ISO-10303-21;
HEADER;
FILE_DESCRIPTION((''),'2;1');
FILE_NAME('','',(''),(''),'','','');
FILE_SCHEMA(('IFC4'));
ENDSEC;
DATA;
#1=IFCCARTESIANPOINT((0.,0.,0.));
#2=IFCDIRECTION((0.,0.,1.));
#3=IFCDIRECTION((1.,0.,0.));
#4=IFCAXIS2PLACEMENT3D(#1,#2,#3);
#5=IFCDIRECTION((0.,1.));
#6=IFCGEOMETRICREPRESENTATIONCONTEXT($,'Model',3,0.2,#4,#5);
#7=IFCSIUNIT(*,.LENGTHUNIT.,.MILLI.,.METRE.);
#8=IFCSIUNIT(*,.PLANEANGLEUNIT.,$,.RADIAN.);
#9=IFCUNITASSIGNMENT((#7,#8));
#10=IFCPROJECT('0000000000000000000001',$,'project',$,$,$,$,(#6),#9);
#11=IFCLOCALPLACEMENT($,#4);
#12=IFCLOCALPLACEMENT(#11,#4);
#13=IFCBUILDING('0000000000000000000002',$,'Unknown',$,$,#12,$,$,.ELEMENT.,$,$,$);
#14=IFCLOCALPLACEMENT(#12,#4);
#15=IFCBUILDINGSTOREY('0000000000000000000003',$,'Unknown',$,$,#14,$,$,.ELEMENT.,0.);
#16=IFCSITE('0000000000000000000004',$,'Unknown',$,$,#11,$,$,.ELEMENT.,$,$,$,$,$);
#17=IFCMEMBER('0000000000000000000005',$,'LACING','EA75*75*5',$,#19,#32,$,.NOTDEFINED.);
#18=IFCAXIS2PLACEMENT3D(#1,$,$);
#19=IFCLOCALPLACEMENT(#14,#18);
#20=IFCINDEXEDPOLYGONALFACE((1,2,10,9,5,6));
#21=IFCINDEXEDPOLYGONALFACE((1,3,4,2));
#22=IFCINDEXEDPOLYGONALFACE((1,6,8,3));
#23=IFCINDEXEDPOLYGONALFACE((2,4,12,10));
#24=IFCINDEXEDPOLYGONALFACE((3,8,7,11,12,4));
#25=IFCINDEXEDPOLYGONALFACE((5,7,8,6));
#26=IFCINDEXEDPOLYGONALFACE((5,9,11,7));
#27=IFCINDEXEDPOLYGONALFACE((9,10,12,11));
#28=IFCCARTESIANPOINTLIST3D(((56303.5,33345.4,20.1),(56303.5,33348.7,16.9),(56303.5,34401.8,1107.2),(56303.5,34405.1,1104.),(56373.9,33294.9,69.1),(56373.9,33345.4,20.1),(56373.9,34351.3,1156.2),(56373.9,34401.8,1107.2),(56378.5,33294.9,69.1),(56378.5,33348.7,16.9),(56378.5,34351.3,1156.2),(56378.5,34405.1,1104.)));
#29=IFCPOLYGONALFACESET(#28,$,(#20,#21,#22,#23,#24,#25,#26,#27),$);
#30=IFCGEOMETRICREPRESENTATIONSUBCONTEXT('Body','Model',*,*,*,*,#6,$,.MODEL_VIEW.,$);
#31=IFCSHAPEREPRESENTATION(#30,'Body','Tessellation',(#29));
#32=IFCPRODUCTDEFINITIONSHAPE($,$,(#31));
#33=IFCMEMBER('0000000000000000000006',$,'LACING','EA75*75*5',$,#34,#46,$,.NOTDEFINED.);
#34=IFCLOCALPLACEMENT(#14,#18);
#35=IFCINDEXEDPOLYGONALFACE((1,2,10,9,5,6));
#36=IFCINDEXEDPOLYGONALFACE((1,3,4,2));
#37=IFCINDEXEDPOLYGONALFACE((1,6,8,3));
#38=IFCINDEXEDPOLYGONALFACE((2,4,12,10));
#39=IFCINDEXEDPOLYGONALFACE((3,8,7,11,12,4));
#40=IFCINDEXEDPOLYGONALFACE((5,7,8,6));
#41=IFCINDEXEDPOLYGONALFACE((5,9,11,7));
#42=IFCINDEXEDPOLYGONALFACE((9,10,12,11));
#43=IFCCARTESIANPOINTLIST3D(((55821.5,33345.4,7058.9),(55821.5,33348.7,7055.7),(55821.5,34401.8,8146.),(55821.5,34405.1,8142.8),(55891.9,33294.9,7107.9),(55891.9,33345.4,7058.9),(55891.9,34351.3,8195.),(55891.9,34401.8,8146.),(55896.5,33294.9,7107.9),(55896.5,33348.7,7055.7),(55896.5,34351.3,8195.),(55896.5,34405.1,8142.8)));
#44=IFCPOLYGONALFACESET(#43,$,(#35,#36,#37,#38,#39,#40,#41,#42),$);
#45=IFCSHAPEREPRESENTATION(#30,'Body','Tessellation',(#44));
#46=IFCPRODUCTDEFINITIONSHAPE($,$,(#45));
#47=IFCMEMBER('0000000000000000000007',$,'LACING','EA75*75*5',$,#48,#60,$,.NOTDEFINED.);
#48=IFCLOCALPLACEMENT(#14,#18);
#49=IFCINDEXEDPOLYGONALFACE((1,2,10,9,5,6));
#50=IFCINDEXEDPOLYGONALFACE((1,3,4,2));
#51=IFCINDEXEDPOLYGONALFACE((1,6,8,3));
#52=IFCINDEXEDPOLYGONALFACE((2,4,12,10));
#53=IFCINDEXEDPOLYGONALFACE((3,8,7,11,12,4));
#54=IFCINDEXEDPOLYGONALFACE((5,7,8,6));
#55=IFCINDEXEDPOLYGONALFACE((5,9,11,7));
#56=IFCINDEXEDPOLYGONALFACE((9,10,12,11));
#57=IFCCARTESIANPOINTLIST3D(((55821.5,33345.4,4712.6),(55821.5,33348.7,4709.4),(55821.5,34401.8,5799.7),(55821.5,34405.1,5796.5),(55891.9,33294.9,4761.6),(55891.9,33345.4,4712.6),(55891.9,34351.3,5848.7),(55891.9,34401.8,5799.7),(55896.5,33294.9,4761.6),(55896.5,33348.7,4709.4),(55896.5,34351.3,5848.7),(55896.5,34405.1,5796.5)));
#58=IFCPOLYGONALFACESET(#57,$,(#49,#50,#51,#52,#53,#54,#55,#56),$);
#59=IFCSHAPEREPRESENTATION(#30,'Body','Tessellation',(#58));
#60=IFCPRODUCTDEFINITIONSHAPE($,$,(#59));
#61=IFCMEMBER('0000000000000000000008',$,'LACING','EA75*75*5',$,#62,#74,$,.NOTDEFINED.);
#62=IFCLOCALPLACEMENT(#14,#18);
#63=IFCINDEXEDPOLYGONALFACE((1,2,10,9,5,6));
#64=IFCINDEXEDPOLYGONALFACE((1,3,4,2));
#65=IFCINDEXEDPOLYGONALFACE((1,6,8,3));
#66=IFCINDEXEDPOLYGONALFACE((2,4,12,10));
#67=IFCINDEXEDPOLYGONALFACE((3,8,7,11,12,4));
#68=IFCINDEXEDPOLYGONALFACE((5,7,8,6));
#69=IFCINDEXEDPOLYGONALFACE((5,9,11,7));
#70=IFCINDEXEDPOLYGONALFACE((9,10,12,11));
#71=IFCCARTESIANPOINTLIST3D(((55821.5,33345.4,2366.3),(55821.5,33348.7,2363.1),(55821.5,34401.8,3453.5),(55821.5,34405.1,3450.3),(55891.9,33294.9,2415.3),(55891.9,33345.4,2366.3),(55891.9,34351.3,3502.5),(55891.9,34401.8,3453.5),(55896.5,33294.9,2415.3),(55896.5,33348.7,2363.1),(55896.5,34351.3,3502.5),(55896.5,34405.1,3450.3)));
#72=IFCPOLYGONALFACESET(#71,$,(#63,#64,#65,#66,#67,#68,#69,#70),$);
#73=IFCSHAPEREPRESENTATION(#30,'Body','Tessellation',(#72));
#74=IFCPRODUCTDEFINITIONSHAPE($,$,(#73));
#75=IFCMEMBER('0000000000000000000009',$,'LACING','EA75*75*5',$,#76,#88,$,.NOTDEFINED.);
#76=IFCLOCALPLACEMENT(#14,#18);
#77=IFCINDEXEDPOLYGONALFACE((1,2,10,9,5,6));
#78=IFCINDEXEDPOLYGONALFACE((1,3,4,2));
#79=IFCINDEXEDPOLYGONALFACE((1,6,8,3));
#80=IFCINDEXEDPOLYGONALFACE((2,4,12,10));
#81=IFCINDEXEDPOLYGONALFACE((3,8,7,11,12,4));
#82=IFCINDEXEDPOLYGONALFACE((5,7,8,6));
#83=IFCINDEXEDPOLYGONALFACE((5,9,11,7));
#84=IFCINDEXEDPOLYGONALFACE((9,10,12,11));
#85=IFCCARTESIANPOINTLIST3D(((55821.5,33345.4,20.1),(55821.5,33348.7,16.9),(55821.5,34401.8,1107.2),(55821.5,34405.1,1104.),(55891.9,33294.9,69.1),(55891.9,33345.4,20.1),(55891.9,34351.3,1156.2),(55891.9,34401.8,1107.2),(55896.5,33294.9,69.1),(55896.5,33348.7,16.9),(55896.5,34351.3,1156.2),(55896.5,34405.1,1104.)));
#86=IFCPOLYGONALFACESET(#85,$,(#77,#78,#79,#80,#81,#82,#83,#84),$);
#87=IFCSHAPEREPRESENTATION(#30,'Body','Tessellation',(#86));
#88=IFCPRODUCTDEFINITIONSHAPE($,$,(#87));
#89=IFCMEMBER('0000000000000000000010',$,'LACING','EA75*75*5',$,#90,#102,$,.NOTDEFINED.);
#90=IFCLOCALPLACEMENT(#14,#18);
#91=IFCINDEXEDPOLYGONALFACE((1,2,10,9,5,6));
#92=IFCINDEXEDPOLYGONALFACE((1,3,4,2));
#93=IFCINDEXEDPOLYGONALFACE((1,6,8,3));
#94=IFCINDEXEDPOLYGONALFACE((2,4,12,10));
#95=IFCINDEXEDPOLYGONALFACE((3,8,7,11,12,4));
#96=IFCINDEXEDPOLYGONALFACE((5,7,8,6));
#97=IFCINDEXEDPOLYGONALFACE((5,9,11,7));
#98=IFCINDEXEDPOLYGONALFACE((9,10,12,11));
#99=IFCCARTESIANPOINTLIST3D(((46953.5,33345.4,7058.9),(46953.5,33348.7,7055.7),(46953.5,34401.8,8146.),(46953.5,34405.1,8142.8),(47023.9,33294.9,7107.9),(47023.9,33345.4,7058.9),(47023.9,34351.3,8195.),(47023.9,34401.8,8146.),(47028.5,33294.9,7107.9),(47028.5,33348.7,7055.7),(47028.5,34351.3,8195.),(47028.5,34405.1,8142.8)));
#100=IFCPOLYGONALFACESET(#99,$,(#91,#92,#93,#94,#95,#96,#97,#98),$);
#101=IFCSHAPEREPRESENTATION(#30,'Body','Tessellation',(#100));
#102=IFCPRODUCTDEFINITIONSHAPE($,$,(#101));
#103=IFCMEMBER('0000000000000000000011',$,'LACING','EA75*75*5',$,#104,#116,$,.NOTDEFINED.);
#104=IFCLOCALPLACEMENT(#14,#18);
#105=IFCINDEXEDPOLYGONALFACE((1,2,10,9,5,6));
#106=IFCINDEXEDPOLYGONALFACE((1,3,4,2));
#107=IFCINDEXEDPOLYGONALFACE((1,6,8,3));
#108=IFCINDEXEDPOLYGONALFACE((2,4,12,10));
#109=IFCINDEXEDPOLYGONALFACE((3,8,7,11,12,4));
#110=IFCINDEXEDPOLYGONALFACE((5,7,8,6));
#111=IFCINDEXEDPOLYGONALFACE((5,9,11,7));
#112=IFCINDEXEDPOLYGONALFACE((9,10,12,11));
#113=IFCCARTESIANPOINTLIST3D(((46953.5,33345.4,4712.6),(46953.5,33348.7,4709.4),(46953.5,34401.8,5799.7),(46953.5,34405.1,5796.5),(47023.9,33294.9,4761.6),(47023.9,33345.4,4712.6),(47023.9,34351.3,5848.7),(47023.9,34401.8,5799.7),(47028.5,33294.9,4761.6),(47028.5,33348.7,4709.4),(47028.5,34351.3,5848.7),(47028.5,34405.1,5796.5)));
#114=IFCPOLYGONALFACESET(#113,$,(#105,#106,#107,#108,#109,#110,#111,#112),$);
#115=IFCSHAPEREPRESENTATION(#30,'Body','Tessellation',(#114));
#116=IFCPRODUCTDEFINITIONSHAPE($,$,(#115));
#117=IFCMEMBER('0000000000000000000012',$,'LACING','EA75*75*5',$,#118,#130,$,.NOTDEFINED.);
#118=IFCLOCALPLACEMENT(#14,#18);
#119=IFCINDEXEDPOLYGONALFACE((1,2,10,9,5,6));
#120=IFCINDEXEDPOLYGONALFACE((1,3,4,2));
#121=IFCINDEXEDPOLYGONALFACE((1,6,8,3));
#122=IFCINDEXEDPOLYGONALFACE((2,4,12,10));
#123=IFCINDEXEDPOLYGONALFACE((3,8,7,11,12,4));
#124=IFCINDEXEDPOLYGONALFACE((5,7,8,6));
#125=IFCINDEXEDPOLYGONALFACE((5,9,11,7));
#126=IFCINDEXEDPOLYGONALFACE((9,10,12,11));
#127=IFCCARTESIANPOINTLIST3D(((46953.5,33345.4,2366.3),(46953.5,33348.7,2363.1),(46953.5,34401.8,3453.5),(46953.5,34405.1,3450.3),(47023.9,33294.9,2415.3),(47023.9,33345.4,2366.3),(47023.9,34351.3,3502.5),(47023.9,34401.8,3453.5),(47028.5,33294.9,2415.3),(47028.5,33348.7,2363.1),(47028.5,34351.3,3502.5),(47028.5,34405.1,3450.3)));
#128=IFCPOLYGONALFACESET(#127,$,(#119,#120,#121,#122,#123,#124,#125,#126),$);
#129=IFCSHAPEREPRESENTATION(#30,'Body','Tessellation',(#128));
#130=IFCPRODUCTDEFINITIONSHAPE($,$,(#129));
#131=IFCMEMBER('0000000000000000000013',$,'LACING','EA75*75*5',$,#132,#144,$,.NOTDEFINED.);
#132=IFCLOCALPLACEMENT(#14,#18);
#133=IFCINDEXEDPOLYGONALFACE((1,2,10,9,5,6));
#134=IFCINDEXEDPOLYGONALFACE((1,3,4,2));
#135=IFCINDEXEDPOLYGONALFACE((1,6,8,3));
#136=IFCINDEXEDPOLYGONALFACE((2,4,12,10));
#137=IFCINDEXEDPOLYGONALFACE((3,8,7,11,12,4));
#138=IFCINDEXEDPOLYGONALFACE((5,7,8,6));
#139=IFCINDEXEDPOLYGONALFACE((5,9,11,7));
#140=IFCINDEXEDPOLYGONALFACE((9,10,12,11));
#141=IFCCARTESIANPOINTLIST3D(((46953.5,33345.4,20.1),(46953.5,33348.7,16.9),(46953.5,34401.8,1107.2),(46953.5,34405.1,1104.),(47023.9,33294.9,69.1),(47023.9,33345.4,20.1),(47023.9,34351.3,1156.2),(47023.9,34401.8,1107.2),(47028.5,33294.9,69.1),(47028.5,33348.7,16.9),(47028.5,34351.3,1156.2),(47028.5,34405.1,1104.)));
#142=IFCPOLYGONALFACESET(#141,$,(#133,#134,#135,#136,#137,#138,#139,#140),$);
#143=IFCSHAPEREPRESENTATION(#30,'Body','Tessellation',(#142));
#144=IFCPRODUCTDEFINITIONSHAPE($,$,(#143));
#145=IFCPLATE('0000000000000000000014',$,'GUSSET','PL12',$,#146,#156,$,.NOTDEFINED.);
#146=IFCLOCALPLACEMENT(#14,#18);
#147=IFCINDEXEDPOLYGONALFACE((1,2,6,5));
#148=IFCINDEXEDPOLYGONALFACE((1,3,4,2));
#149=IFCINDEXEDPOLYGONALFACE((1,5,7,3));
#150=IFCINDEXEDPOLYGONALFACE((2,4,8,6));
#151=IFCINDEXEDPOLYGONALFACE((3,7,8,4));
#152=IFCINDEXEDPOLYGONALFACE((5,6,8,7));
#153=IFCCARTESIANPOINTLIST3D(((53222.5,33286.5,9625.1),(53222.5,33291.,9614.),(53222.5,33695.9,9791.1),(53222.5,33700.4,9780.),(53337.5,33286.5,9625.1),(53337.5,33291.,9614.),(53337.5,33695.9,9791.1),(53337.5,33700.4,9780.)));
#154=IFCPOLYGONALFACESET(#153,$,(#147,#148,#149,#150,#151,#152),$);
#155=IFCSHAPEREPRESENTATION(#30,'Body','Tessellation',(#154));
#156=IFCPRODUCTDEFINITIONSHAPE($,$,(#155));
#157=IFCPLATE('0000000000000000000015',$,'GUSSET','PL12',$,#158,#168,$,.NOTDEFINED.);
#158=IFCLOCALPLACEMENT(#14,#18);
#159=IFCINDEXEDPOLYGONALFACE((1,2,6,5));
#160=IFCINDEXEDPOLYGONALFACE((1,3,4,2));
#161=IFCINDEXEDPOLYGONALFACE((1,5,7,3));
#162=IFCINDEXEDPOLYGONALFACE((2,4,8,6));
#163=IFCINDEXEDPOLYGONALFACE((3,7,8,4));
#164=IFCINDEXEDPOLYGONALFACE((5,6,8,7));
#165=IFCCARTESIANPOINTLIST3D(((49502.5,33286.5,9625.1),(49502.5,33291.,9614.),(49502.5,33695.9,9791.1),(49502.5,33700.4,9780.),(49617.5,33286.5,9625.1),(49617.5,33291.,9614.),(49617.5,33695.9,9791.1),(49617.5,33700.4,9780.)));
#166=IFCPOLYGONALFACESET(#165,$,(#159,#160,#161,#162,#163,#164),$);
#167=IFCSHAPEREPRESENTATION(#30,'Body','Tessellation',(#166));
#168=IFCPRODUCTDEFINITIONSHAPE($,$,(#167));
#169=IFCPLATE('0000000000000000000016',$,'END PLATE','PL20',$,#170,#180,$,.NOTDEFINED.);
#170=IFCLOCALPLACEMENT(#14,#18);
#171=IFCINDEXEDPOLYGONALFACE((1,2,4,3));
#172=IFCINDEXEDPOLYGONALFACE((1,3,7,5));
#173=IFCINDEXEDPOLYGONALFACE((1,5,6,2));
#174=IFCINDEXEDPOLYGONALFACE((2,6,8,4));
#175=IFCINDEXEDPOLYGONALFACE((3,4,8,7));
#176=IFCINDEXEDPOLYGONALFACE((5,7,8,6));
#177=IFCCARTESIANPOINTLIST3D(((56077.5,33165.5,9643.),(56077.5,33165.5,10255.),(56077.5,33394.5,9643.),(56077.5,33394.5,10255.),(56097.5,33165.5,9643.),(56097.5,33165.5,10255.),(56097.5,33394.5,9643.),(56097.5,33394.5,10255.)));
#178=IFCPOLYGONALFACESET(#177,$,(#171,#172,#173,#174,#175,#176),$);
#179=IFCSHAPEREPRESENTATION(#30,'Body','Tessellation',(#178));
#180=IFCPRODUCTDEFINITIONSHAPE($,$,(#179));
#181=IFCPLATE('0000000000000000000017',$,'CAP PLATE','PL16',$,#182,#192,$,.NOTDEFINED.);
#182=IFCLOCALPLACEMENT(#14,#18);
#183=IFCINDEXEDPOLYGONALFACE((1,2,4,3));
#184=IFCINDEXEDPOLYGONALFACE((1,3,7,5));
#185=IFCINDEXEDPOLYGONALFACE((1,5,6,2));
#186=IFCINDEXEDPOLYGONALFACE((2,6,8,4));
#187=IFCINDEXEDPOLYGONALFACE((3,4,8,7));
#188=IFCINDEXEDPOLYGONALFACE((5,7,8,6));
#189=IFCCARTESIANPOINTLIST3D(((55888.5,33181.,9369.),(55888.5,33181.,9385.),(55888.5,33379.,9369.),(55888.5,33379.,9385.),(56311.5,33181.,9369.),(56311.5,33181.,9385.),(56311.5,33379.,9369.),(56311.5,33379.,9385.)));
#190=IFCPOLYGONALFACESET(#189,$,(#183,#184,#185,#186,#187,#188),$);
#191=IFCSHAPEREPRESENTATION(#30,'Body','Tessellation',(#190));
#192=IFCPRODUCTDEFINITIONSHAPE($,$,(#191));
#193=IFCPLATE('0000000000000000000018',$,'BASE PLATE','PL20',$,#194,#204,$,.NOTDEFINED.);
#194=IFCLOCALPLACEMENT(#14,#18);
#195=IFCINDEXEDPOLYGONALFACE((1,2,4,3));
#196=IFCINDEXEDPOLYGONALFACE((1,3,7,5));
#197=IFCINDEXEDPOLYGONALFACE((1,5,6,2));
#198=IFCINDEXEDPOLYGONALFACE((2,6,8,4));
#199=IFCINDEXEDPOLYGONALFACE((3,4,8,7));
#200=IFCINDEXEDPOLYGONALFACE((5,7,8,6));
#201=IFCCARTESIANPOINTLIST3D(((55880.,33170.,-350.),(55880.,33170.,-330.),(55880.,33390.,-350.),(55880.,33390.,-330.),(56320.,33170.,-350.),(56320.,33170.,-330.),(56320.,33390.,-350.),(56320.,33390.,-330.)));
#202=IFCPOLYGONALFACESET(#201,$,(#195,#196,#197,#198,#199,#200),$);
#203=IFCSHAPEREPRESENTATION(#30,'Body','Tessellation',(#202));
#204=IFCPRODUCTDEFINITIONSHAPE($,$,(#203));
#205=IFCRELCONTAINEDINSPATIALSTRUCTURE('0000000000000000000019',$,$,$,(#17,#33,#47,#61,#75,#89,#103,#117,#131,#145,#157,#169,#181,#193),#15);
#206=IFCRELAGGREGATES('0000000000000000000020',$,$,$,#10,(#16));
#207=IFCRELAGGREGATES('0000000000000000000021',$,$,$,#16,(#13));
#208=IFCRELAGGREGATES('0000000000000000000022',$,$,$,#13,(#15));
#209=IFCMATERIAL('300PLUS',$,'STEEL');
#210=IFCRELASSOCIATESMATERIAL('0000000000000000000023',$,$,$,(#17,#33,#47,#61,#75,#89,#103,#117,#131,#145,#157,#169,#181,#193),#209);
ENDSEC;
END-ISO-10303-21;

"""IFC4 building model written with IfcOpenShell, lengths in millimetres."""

from ifc_helpers import new_model, si_unit, direction, frame, origin_with_axes, place, context, subcontext, project, spatial, line, indexed_curve, outline, extrude, material, element, save


model = new_model("IFC4")

# Units and contexts
model_context = context("Model", 3, precision=0.2, world=origin_with_axes(), true_north=direction((0.0, 1.0)))
body_context = subcontext(model_context, "Body", "Model", "MODEL_VIEW")
ifc_project = project(units=[si_unit("LENGTHUNIT", "METRE", prefix="MILLI"), si_unit("PLANEANGLEUNIT", "RADIAN")], contexts=[model_context])

# Site, building, storey
site_placement = place(None, origin_with_axes())
site = spatial("IfcSite", under=ifc_project, at=site_placement, Name="Unknown", CompositionType="ELEMENT")
building_placement = place(site_placement, origin_with_axes())
building = spatial("IfcBuilding", under=site, at=building_placement, Name="Unknown", CompositionType="ELEMENT")
storey_placement = place(building_placement, origin_with_axes())
storey = spatial("IfcBuildingStorey", under=building, at=storey_placement, Name="Unknown", CompositionType="ELEMENT", Elevation=0.0)

# Shared definitions
ifc_material_1 = material(Name="300PLUS", Category="STEEL")

# Members
for number, where, z_axis, x_axis, name in (
    (1, (56341.0, 33321.8, 43.0), (0.0, -0.717161, 0.696908), (0.0, 0.696908, 0.717161), "LACING"),
    (2, (55859.0, 33321.8, 7081.8), (0.0, -0.717161, 0.696908), (0.0, 0.696908, 0.717161), "LACING"),
    (3, (55859.0, 33321.8, 4735.5), (0.0, -0.717161, 0.696908), (0.0, 0.696908, 0.717161), "LACING"),
):
    element("IfcMember", number, at=place(storey_placement, frame(where, z_axis=z_axis, x_axis=x_axis)), inside=storey, material=ifc_material_1, Name=name, Description="EA75*75*5", PredefinedType="NOTDEFINED", context=body_context, shape_type="SolidModel", body=[
        extrude(outline(indexed_curve([(-37.5, -37.5), (37.5, -37.5), (37.5, -32.9), (-32.9, -32.9), (-32.9, 37.5), (-37.5, 37.5)], segments=[line(1, 2, 3, 4, 5, 6, 1)])), frame((0.0, 0.0, 0.0), z_axis=(-1.0, 0.0, 0.0), x_axis=(0.0, 0.0, 1.0)), (0.0, 0.0, -1.0), 1515.8),
    ])
member_1_placement = place(storey_placement, frame((55859.0, 33321.8, 2389.2), z_axis=(0.0, -0.717193, 0.696875), x_axis=(0.0, 0.696875, 0.717193)))
element("IfcMember", 4, at=member_1_placement, inside=storey, material=ifc_material_1, Name="LACING", Description="EA75*75*5", PredefinedType="NOTDEFINED", context=body_context, shape_type="SolidModel", body=[
    extrude(outline(indexed_curve([(-37.5, -37.5), (37.5, -37.5), (37.5, -32.9), (-32.9, -32.9), (-32.9, 37.5), (-37.5, 37.5)], segments=[line(1, 2, 3, 4, 5, 6, 1)])), frame((0.0, 0.0, 0.0), z_axis=(-1.0, 0.0, 0.0), x_axis=(0.0, 0.0, 1.0)), (0.0, 0.0, -1.0), 1515.9),
])
for number, where, z_axis, x_axis, name in (
    (5, (55859.0, 33321.8, 43.0), (0.0, -0.717161, 0.696908), (0.0, 0.696908, 0.717161), "LACING"),
    (6, (46991.0, 33321.8, 7081.8), (0.0, -0.717161, 0.696908), (0.0, 0.696908, 0.717161), "LACING"),
    (7, (46991.0, 33321.8, 4735.5), (0.0, -0.717161, 0.696908), (0.0, 0.696908, 0.717161), "LACING"),
):
    element("IfcMember", number, at=place(storey_placement, frame(where, z_axis=z_axis, x_axis=x_axis)), inside=storey, material=ifc_material_1, Name=name, Description="EA75*75*5", PredefinedType="NOTDEFINED", context=body_context, shape_type="SolidModel", body=[
        extrude(outline(indexed_curve([(-37.5, -37.5), (37.5, -37.5), (37.5, -32.9), (-32.9, -32.9), (-32.9, 37.5), (-37.5, 37.5)], segments=[line(1, 2, 3, 4, 5, 6, 1)])), frame((0.0, 0.0, 0.0), z_axis=(-1.0, 0.0, 0.0), x_axis=(0.0, 0.0, 1.0)), (0.0, 0.0, -1.0), 1515.8),
    ])
member_2_placement = place(storey_placement, frame((46991.0, 33321.8, 2389.2), z_axis=(0.0, -0.717193, 0.696875), x_axis=(0.0, 0.696875, 0.717193)))
element("IfcMember", 8, at=member_2_placement, inside=storey, material=ifc_material_1, Name="LACING", Description="EA75*75*5", PredefinedType="NOTDEFINED", context=body_context, shape_type="SolidModel", body=[
    extrude(outline(indexed_curve([(-37.5, -37.5), (37.5, -37.5), (37.5, -32.9), (-32.9, -32.9), (-32.9, 37.5), (-37.5, 37.5)], segments=[line(1, 2, 3, 4, 5, 6, 1)])), frame((0.0, 0.0, 0.0), z_axis=(-1.0, 0.0, 0.0), x_axis=(0.0, 0.0, 1.0)), (0.0, 0.0, -1.0), 1515.9),
])
member_3_placement = place(storey_placement, frame((46991.0, 33321.8, 43.0), z_axis=(0.0, -0.717161, 0.696908), x_axis=(0.0, 0.696908, 0.717161)))
element("IfcMember", 9, at=member_3_placement, inside=storey, material=ifc_material_1, Name="LACING", Description="EA75*75*5", PredefinedType="NOTDEFINED", context=body_context, shape_type="SolidModel", body=[
    extrude(outline(indexed_curve([(-37.5, -37.5), (37.5, -37.5), (37.5, -32.9), (-32.9, -32.9), (-32.9, 37.5), (-37.5, 37.5)], segments=[line(1, 2, 3, 4, 5, 6, 1)])), frame((0.0, 0.0, 0.0), z_axis=(-1.0, 0.0, 0.0), x_axis=(0.0, 0.0, 1.0)), (0.0, 0.0, -1.0), 1515.8),
])

# Plates
for number, where, z_axis, x_axis, name in (
    (10, (53337.5, 33288.7, 9619.6), (0.0, -0.375758, 0.926718), (0.0, 0.926718, 0.375758), "GUSSET"),
    (11, (49617.5, 33288.7, 9619.6), (0.0, -0.375758, 0.926718), (0.0, 0.926718, 0.375758), "GUSSET"),
):
    element("IfcPlate", number, at=place(storey_placement, frame(where, z_axis=z_axis, x_axis=x_axis)), inside=storey, material=ifc_material_1, Name=name, Description="PL12", PredefinedType="NOTDEFINED", context=body_context, shape_type="SolidModel", body=[
        extrude(outline(indexed_curve([(0.0, 0.0), (441.8, 0.0), (441.8, 115.0), (0.0, 115.0)], segments=[line(1, 2, 3, 4, 1)])), frame((0.0, 0.0, 6.0), z_axis=(0.0, 0.0, 1.0), x_axis=(1.0, 0.0, 0.0)), (0.0, 0.0, -1.0), 12.0),
    ])
plate_1_placement = place(storey_placement, frame((56087.5, 33394.5, 9643.0), z_axis=(-1.0, 0.0, 0.0), x_axis=(0.0, -1.0, 0.0)))
element("IfcPlate", 12, at=plate_1_placement, inside=storey, material=ifc_material_1, Name="END PLATE", Description="PL20", PredefinedType="NOTDEFINED", context=body_context, shape_type="SolidModel", body=[
    extrude(outline(indexed_curve([(0.0, 0.0), (229.0, 0.0), (229.0, 612.0), (0.0, 612.0)], segments=[line(1, 2, 3, 4, 1)])), frame((0.0, 0.0, 10.0), z_axis=(0.0, 0.0, 1.0), x_axis=(1.0, 0.0, 0.0)), (0.0, 0.0, -1.0), 20.0),
])
plate_2_placement = place(storey_placement, frame((55888.5, 33181.0, 9377.0), z_axis=(0.0, 0.0, 1.0), x_axis=(1.0, 0.0, 0.0)))
element("IfcPlate", 13, at=plate_2_placement, inside=storey, material=ifc_material_1, Name="CAP PLATE", Description="PL16", PredefinedType="NOTDEFINED", context=body_context, shape_type="SolidModel", body=[
    extrude(outline(indexed_curve([(0.0, 0.0), (423.0, 0.0), (423.0, 198.0), (0.0, 198.0)], segments=[line(1, 2, 3, 4, 1)])), frame((0.0, 0.0, 8.0), z_axis=(0.0, 0.0, 1.0), x_axis=(1.0, 0.0, 0.0)), (0.0, 0.0, -1.0), 16.0),
])
plate_3_placement = place(storey_placement, frame((55880.0, 33170.0, -340.0), z_axis=(0.0, 0.0, 1.0), x_axis=(1.0, 0.0, 0.0)))
element("IfcPlate", 14, at=plate_3_placement, inside=storey, material=ifc_material_1, Name="BASE PLATE", Description="PL20", PredefinedType="NOTDEFINED", context=body_context, shape_type="SolidModel", body=[
    extrude(outline(indexed_curve([(0.0, 0.0), (440.0, 0.0), (440.0, 220.0), (0.0, 220.0)], segments=[line(1, 2, 3, 4, 1)])), frame((0.0, 0.0, 10.0), z_axis=(0.0, 0.0, 1.0), x_axis=(1.0, 0.0, 0.0)), (0.0, 0.0, -1.0), 20.0),
])

save(model, "model.ifc")
